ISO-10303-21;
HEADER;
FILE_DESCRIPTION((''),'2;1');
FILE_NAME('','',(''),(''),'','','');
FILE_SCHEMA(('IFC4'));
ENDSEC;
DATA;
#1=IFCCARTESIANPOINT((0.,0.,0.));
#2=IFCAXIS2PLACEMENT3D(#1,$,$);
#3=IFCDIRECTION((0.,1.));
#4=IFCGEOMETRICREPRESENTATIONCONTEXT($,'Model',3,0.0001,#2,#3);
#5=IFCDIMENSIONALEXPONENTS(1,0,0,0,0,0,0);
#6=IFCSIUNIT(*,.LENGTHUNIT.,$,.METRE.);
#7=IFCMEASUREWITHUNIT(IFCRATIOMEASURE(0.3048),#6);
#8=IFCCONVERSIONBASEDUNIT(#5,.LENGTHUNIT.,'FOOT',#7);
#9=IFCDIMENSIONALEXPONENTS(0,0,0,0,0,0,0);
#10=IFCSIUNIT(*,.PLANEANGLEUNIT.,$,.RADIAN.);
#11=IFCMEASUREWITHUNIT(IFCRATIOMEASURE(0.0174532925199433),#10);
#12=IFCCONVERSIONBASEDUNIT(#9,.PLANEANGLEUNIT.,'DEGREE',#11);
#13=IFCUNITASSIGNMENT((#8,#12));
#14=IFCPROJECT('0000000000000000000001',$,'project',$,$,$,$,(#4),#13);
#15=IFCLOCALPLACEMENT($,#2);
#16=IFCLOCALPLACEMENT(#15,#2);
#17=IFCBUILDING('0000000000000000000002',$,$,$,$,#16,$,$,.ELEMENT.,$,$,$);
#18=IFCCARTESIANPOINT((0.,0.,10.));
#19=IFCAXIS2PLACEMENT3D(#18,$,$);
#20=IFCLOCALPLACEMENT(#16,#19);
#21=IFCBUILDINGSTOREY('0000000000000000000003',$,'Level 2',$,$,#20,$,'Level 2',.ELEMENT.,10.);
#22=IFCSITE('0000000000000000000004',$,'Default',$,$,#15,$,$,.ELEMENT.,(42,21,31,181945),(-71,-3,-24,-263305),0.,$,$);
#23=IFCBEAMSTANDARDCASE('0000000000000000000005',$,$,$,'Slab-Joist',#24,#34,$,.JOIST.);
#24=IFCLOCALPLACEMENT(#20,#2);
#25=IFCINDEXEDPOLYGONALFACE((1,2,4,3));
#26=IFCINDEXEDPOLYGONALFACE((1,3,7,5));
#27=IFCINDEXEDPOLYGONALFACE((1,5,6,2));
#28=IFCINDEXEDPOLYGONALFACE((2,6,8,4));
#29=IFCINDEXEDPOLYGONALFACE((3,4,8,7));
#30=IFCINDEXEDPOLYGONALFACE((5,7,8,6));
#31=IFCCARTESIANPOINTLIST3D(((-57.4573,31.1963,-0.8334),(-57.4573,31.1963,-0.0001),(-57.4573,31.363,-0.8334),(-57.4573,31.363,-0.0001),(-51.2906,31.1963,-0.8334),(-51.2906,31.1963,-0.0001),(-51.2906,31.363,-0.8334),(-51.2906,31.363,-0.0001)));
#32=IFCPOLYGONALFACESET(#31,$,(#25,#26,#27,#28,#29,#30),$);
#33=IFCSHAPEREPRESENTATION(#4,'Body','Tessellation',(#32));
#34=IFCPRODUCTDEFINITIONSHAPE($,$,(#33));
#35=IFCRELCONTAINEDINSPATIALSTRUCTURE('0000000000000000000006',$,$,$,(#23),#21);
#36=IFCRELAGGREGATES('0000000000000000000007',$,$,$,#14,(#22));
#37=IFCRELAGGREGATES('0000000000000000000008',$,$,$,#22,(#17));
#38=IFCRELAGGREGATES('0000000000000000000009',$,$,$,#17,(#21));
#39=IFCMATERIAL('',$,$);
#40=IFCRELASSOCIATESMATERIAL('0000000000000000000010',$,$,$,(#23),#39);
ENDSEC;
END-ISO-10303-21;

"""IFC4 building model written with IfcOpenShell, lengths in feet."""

from ifc_helpers import new_model, entity, si_unit, converted_unit, direction, frame, origin, origin_with_axes, place, context, project, spatial, rectangle, extrude, material, element, save


model = new_model("IFC4")

# Units and contexts
model_context = context("Model", 3, precision=0.0001, world=origin(), true_north=direction((0.0, 1.0)))
ifc_project = project(units=[converted_unit("LENGTHUNIT", "FOOT", entity("IfcRatioMeasure", 0.3048), si_unit("LENGTHUNIT", "METRE"), dimensions=[1, 0, 0, 0, 0, 0, 0]), converted_unit("PLANEANGLEUNIT", "DEGREE", entity("IfcRatioMeasure", 0.0174532925199433), si_unit("PLANEANGLEUNIT", "RADIAN"), dimensions=[0, 0, 0, 0, 0, 0, 0])], contexts=[model_context])

# Site, building, storey
site_placement = place(None, origin())
site = spatial("IfcSite", under=ifc_project, at=site_placement, Name="Default", CompositionType="ELEMENT", RefLatitude=(42, 21, 31, 181945), RefLongitude=(-71, -3, -24, -263305), RefElevation=0.0)
building_placement = place(site_placement, origin())
building = spatial("IfcBuilding", under=site, at=building_placement, CompositionType="ELEMENT")
storey_placement = place(building_placement, frame((0.0, 0.0, 10.0)))
storey = spatial("IfcBuildingStorey", under=building, at=storey_placement, Name="Level 2", LongName="Level 2", CompositionType="ELEMENT", Elevation=10.0)

# Beam
ifc_material_1 = material(Name="")
placement_1 = place(storey_placement, frame((-57.4573, 31.2797, 0.0), z_axis=(0.0, 0.0, 1.0), x_axis=(1.0, 0.0, 0.0)))
beam_1_placement = place(placement_1, frame((0.0, 0.0, -0.4167), z_axis=(1.0, 0.0, 0.0), x_axis=(0.0, 1.0, 0.0)))
element("IfcBeamStandardCase", 1, at=beam_1_placement, inside=storey, material=ifc_material_1, ObjectType="Slab-Joist", PredefinedType="JOIST", context=model_context, shape_type="SweptSolid", body=[
    extrude(rectangle(XDim=0.1667, YDim=0.8333), origin_with_axes(), (0.0, 0.0, 1.0), 6.1667),
])

save(model, "model.ifc")
